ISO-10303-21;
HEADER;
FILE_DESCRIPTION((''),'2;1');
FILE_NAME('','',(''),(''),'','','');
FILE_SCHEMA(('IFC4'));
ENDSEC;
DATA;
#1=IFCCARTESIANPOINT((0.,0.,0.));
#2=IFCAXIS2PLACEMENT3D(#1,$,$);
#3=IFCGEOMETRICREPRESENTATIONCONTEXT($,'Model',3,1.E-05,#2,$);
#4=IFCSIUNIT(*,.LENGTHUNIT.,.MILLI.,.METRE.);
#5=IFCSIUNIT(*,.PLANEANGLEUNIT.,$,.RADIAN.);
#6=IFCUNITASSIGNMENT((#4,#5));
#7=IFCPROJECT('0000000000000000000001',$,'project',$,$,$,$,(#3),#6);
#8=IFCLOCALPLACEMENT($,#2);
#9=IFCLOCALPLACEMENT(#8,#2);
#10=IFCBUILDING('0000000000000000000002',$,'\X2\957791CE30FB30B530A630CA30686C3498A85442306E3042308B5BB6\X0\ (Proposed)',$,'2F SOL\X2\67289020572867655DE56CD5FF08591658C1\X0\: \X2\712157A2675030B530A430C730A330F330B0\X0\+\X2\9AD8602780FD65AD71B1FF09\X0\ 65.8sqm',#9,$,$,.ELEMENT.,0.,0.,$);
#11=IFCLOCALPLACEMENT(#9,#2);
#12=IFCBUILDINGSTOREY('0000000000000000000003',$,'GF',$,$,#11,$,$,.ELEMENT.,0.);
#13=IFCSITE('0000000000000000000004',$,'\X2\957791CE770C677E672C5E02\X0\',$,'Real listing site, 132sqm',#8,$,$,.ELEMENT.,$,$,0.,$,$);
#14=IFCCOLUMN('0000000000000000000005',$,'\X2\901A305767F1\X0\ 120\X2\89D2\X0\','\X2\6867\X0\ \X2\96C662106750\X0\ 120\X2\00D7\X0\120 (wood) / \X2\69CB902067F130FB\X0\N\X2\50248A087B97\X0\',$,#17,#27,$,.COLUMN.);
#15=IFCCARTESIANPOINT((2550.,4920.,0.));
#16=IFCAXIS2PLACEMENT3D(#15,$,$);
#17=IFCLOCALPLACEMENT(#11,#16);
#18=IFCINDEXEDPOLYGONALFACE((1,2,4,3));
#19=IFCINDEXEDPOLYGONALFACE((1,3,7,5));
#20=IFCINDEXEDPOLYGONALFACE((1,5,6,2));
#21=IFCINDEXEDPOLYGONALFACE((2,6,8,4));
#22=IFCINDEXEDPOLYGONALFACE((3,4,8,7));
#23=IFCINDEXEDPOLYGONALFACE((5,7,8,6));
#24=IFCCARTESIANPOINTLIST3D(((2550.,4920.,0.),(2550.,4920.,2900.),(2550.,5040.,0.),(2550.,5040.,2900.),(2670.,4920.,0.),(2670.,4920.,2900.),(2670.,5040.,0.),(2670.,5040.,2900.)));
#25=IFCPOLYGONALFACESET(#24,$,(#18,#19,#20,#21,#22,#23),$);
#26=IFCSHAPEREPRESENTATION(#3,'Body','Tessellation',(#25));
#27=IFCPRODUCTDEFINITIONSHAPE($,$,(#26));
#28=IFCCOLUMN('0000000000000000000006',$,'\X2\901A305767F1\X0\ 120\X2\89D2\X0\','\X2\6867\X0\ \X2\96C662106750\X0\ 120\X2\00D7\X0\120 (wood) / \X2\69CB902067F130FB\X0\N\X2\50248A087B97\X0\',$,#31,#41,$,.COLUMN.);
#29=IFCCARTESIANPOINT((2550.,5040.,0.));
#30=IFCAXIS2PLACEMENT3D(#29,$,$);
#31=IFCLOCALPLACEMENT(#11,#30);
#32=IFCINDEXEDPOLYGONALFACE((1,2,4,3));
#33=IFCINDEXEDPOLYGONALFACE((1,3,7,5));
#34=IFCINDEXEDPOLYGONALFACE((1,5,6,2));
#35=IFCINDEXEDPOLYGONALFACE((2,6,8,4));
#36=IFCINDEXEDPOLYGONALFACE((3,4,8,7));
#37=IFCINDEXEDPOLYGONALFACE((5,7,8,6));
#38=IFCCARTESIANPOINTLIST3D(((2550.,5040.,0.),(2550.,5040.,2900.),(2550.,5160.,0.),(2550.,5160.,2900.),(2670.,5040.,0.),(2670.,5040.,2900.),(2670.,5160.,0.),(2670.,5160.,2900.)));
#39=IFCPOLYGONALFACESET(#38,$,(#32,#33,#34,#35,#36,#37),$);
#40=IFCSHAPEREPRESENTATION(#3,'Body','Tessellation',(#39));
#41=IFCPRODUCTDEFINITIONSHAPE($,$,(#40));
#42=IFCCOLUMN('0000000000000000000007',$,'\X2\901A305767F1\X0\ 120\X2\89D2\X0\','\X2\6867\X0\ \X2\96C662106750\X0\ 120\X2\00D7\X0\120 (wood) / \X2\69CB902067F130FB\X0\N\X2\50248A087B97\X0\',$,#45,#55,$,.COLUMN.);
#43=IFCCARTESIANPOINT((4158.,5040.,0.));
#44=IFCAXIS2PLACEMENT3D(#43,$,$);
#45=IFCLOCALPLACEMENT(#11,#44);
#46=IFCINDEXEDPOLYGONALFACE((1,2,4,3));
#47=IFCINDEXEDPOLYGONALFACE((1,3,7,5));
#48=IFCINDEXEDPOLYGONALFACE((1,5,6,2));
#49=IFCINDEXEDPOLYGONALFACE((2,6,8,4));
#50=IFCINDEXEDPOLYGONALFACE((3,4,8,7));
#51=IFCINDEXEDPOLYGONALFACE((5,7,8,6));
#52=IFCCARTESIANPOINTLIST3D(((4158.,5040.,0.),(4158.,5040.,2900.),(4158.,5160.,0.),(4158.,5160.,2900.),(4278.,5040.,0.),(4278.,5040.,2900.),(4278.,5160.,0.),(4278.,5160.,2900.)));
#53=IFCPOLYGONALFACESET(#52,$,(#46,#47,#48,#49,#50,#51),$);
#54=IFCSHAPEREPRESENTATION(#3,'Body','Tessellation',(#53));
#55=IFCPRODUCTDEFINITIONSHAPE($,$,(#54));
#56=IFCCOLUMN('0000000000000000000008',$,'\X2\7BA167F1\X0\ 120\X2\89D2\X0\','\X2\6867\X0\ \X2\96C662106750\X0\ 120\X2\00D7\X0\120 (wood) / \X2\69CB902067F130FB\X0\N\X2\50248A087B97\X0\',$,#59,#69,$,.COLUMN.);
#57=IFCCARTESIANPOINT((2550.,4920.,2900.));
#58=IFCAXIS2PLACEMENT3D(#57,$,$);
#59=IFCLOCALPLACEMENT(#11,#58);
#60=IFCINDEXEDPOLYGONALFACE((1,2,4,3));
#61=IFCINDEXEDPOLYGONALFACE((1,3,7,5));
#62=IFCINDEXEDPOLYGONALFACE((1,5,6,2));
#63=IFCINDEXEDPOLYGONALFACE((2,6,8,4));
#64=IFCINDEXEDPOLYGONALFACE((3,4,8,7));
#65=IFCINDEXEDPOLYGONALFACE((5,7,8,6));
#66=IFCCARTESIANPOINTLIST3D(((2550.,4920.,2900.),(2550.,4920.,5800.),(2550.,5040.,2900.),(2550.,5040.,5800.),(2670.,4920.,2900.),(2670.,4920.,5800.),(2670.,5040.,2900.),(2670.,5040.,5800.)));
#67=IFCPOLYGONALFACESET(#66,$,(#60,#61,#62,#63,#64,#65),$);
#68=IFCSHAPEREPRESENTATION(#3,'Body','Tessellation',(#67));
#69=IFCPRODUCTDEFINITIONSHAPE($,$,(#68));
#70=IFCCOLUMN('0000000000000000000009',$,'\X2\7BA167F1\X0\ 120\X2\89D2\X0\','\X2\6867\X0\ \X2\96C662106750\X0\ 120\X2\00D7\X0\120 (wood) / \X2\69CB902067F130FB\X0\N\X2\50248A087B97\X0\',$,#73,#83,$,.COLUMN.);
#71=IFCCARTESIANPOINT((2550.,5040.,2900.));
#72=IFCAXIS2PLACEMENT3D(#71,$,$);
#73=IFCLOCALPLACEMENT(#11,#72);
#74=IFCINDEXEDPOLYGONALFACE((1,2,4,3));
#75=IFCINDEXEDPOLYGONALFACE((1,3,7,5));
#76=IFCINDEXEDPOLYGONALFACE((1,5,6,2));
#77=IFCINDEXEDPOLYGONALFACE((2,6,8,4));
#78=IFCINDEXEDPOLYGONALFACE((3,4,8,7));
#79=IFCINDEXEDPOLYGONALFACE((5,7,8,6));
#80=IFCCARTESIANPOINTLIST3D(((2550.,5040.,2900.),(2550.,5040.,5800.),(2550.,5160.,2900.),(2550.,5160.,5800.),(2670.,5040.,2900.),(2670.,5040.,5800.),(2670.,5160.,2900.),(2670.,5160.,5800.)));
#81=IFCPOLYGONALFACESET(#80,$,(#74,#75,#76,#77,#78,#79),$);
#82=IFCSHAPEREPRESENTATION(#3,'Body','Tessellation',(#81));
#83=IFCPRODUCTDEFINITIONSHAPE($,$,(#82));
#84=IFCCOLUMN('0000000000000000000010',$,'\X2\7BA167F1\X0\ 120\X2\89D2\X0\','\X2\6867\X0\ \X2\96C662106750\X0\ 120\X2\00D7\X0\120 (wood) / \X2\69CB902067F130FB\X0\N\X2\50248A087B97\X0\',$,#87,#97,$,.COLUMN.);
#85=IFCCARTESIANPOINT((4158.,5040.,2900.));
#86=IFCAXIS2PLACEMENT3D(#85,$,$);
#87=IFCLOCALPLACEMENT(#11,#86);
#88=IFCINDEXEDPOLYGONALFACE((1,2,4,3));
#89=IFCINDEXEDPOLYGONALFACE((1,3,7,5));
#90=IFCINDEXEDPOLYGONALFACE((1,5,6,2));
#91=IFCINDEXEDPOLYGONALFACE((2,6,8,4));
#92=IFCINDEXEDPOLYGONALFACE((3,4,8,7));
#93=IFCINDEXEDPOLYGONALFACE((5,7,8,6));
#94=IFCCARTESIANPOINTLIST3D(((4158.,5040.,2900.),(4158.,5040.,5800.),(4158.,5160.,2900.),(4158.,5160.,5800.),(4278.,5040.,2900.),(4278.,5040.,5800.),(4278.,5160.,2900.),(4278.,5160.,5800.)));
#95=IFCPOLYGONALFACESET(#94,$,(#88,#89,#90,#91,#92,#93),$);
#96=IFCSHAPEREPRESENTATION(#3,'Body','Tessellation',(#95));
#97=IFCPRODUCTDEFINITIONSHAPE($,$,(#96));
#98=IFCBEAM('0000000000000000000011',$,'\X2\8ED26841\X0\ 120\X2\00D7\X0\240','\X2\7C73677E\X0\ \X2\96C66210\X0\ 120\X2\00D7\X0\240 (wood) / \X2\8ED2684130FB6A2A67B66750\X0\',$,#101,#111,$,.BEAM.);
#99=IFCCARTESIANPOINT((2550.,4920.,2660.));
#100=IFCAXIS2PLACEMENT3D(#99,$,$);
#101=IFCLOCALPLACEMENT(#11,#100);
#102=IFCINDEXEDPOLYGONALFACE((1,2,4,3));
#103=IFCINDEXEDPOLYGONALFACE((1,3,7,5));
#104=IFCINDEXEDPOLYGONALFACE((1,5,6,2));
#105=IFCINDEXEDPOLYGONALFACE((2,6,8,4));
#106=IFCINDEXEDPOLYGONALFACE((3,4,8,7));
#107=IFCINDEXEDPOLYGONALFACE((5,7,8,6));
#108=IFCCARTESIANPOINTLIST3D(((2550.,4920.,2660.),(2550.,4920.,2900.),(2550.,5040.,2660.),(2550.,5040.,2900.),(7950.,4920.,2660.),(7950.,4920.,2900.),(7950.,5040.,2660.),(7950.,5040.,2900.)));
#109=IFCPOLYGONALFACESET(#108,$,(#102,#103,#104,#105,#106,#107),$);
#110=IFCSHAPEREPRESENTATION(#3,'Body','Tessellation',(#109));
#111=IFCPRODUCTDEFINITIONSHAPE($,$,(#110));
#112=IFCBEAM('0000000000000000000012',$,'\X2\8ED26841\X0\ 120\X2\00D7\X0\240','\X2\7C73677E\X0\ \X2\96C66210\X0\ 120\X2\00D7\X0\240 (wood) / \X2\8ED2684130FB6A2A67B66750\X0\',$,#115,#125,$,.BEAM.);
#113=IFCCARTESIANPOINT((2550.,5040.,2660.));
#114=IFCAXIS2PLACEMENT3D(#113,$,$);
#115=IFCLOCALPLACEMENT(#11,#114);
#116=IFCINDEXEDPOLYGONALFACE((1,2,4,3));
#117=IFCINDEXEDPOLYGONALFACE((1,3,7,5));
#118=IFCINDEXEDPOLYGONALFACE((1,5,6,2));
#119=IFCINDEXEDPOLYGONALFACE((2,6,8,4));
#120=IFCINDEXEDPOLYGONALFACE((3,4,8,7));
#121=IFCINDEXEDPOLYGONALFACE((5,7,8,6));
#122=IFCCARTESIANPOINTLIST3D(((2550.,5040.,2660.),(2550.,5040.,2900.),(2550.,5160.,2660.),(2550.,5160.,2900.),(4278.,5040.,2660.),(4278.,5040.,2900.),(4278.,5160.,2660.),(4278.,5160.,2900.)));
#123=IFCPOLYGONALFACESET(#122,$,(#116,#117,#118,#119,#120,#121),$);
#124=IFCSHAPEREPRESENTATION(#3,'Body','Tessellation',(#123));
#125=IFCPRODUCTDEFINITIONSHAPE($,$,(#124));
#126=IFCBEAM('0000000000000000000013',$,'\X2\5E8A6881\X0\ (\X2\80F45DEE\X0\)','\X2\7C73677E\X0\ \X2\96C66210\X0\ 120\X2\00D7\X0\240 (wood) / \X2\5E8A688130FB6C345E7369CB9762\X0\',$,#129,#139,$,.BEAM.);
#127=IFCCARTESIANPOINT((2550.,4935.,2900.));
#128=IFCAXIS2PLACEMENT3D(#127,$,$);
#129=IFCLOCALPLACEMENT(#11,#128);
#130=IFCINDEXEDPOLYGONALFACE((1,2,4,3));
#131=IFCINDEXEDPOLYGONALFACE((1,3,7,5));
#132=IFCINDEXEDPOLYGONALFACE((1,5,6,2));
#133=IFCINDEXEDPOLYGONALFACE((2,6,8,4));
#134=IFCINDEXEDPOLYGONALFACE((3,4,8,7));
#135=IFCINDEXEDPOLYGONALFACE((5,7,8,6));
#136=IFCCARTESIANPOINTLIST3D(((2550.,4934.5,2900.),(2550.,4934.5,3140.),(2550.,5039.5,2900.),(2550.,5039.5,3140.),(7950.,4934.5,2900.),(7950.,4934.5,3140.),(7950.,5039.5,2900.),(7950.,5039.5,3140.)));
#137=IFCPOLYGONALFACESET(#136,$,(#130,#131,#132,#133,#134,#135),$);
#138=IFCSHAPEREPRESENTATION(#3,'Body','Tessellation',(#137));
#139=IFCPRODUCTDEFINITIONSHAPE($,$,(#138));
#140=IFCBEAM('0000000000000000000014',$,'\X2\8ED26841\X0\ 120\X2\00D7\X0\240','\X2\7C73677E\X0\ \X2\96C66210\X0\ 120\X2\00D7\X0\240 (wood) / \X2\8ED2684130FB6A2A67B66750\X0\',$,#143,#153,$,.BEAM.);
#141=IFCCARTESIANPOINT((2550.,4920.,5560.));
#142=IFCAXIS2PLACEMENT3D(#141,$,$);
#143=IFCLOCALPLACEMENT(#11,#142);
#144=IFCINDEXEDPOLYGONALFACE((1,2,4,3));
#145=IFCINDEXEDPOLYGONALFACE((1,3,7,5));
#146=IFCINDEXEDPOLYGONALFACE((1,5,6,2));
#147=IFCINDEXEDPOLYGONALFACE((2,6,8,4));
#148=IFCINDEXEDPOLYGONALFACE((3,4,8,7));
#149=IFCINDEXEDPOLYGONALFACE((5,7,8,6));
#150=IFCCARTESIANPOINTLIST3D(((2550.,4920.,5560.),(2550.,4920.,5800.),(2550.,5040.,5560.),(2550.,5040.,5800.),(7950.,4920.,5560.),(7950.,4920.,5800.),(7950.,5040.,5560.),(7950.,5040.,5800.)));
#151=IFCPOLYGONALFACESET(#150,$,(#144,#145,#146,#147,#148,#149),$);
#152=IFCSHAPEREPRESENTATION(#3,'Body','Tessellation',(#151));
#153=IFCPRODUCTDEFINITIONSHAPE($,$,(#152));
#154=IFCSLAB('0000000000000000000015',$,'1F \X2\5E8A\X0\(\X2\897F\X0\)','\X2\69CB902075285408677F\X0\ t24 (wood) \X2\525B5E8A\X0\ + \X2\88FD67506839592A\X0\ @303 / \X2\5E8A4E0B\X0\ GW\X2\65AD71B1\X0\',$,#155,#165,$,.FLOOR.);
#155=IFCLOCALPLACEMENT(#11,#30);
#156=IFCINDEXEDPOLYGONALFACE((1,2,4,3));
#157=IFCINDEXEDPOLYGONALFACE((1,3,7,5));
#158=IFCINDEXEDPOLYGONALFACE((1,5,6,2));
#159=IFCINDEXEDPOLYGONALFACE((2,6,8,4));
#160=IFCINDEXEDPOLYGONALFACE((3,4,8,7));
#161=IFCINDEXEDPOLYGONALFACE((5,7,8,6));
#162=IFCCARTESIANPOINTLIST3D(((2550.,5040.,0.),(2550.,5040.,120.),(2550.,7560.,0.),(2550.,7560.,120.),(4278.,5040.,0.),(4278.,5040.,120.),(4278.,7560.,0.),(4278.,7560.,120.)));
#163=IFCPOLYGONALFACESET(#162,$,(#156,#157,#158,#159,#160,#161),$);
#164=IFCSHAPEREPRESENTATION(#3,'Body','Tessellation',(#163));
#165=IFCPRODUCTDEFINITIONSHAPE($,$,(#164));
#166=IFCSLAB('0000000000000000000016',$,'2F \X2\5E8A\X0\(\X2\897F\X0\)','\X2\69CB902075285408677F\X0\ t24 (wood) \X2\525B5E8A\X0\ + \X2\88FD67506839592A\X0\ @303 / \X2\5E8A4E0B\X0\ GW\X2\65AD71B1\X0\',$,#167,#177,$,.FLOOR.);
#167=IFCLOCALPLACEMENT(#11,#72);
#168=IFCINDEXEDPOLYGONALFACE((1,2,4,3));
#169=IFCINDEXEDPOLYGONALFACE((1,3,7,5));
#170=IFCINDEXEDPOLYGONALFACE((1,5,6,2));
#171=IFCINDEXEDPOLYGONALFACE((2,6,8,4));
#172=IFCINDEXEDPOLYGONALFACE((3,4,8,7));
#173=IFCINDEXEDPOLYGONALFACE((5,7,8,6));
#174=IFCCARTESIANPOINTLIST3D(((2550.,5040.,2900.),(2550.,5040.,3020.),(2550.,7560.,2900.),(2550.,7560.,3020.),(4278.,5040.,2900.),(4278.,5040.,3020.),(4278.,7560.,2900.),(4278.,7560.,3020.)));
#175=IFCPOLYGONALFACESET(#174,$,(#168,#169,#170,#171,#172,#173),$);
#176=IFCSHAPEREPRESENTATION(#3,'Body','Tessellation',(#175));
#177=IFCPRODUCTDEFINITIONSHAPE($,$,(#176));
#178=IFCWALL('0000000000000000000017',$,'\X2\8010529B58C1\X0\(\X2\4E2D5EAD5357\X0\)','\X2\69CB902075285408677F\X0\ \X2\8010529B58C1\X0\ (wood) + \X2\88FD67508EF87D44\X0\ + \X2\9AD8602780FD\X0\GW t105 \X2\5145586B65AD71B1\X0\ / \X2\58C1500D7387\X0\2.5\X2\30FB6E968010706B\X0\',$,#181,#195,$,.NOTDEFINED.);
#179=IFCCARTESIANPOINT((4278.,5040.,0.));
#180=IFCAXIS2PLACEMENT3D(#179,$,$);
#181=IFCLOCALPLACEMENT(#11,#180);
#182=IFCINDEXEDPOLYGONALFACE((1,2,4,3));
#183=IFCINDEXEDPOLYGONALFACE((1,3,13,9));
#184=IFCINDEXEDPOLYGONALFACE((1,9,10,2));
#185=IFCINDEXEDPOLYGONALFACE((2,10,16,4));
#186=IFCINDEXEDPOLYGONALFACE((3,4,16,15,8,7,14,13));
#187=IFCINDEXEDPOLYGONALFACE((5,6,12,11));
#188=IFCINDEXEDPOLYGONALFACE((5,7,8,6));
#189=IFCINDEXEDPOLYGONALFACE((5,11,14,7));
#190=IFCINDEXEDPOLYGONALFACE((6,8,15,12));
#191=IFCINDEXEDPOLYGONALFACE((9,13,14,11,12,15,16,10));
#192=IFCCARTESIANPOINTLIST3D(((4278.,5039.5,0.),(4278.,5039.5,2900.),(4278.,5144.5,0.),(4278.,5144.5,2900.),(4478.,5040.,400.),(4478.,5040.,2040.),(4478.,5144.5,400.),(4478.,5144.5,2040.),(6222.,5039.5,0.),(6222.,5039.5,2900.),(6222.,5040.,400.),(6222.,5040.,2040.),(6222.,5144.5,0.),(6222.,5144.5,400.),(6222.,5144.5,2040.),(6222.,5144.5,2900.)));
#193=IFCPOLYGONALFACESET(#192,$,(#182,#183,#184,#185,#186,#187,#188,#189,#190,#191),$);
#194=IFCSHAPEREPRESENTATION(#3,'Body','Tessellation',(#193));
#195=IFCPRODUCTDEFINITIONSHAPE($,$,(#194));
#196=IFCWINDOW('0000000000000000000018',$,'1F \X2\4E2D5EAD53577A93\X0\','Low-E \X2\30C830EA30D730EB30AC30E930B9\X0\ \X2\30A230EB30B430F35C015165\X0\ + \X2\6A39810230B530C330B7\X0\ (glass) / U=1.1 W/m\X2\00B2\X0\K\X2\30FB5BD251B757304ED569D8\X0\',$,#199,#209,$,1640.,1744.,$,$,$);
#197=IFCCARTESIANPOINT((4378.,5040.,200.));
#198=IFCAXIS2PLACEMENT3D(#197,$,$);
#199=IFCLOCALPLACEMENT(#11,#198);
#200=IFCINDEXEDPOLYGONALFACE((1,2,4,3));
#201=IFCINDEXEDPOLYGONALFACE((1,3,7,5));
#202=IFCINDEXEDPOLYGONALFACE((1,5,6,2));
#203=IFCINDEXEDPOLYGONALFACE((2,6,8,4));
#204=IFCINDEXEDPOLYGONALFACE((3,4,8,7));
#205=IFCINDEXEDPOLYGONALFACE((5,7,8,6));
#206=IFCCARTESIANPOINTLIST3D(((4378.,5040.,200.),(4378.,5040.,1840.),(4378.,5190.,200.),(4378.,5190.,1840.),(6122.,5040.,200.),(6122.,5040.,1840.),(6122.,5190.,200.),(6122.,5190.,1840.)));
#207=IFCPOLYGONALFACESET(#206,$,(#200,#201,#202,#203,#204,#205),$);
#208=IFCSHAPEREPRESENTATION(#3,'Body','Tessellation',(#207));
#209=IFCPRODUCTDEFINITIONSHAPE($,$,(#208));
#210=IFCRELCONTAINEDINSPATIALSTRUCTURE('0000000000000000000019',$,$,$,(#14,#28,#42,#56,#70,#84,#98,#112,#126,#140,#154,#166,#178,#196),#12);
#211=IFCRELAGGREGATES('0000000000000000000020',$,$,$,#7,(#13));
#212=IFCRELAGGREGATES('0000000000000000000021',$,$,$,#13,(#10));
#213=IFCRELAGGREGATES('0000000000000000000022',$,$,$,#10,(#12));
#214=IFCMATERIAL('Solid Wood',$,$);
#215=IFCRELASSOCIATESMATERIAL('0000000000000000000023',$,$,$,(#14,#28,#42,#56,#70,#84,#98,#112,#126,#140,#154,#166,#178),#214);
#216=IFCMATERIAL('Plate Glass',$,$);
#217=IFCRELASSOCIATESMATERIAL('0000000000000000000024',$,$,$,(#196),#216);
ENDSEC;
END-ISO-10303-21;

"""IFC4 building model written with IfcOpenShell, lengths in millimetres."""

from ifc_helpers import new_model, si_unit, frame, frame_2d, origin, place, context, project, spatial, rectangle, extrude, material, element, fill, save


model = new_model("IFC4")

# Units and contexts
model_context = context("Model", 3, precision=1e-05, world=origin())
ifc_project = project(units=[si_unit("LENGTHUNIT", "METRE", prefix="MILLI"), si_unit("PLANEANGLEUNIT", "RADIAN")], contexts=[model_context])

# Site, building, storey
site_placement = place(None, origin())
site = spatial("IfcSite", under=ifc_project, at=site_placement, Name="長野県松本市", ObjectType="Real listing site, 132sqm", CompositionType="ELEMENT", RefElevation=0.0)
building_placement = place(site_placement, origin())
building = spatial("IfcBuilding", under=site, at=building_placement, Name="長野・サウナと水風呂のある家 (Proposed)", ObjectType="2F SOL木造在来工法（外壁: 無垢材サイディング+高性能断熱） 65.8sqm", CompositionType="ELEMENT", ElevationOfRefHeight=0.0, ElevationOfTerrain=0.0)
storey_placement = place(building_placement, origin())
storey = spatial("IfcBuildingStorey", under=building, at=storey_placement, Name="GF", CompositionType="ELEMENT", Elevation=0.0)

# Columns
ifc_material_1 = material(Name="Solid Wood")
column_1_placement = place(storey_placement, frame((2550.0, 4920.0, 0.0)))
element("IfcColumn", 1, at=column_1_placement, inside=storey, material=ifc_material_1, Name="通し柱 120角", Description="桧 集成材 120×120 (wood) / 構造柱・N値計算", PredefinedType="COLUMN", context=model_context, shape_type="SweptSolid", body=[
    extrude(rectangle(XDim=120.0, YDim=120.0, at=frame_2d((60.0, 60.0))), frame((2550.0, 4920.0, 0.0)), (0.0, 0.0, 1.0), 2900.0),
])
column_2_placement = place(storey_placement, frame((2550.0, 5040.0, 0.0)))
element("IfcColumn", 2, at=column_2_placement, inside=storey, material=ifc_material_1, Name="通し柱 120角", Description="桧 集成材 120×120 (wood) / 構造柱・N値計算", PredefinedType="COLUMN", context=model_context, shape_type="SweptSolid", body=[
    extrude(rectangle(XDim=120.0, YDim=120.0, at=frame_2d((60.0, 60.0))), frame((2550.0, 5040.0, 0.0)), (0.0, 0.0, 1.0), 2900.0),
])
column_3_placement = place(storey_placement, frame((4158.0, 5040.0, 0.0)))
element("IfcColumn", 3, at=column_3_placement, inside=storey, material=ifc_material_1, Name="通し柱 120角", Description="桧 集成材 120×120 (wood) / 構造柱・N値計算", PredefinedType="COLUMN", context=model_context, shape_type="SweptSolid", body=[
    extrude(rectangle(XDim=120.0, YDim=120.0, at=frame_2d((60.0, 60.0))), frame((4158.0, 5040.0, 0.0)), (0.0, 0.0, 1.0), 2900.0),
])
column_4_placement = place(storey_placement, frame((2550.0, 4920.0, 2900.0)))
element("IfcColumn", 4, at=column_4_placement, inside=storey, material=ifc_material_1, Name="管柱 120角", Description="桧 集成材 120×120 (wood) / 構造柱・N値計算", PredefinedType="COLUMN", context=model_context, shape_type="SweptSolid", body=[
    extrude(rectangle(XDim=120.0, YDim=120.0, at=frame_2d((60.0, 60.0))), frame((2550.0, 4920.0, 2900.0)), (0.0, 0.0, 1.0), 2900.0),
])
column_5_placement = place(storey_placement, frame((2550.0, 5040.0, 2900.0)))
element("IfcColumn", 5, at=column_5_placement, inside=storey, material=ifc_material_1, Name="管柱 120角", Description="桧 集成材 120×120 (wood) / 構造柱・N値計算", PredefinedType="COLUMN", context=model_context, shape_type="SweptSolid", body=[
    extrude(rectangle(XDim=120.0, YDim=120.0, at=frame_2d((60.0, 60.0))), frame((2550.0, 5040.0, 2900.0)), (0.0, 0.0, 1.0), 2900.0),
])
column_6_placement = place(storey_placement, frame((4158.0, 5040.0, 2900.0)))
element("IfcColumn", 6, at=column_6_placement, inside=storey, material=ifc_material_1, Name="管柱 120角", Description="桧 集成材 120×120 (wood) / 構造柱・N値計算", PredefinedType="COLUMN", context=model_context, shape_type="SweptSolid", body=[
    extrude(rectangle(XDim=120.0, YDim=120.0, at=frame_2d((60.0, 60.0))), frame((4158.0, 5040.0, 2900.0)), (0.0, 0.0, 1.0), 2900.0),
])

# Beams
beam_1_placement = place(storey_placement, frame((2550.0, 4920.0, 2660.0)))
element("IfcBeam", 7, at=beam_1_placement, inside=storey, material=ifc_material_1, Name="軒桁 120×240", Description="米松 集成 120×240 (wood) / 軒桁・横架材", PredefinedType="BEAM", context=model_context, shape_type="SweptSolid", body=[
    extrude(rectangle(XDim=5400.0, YDim=120.0, at=frame_2d((2700.0, 60.0))), frame((2550.0, 4920.0, 2660.0)), (0.0, 0.0, 1.0), 240.0),
])
beam_2_placement = place(storey_placement, frame((2550.0, 5040.0, 2660.0)))
element("IfcBeam", 8, at=beam_2_placement, inside=storey, material=ifc_material_1, Name="軒桁 120×240", Description="米松 集成 120×240 (wood) / 軒桁・横架材", PredefinedType="BEAM", context=model_context, shape_type="SweptSolid", body=[
    extrude(rectangle(XDim=1728.0, YDim=120.0, at=frame_2d((864.0, 60.0))), frame((2550.0, 5040.0, 2660.0)), (0.0, 0.0, 1.0), 240.0),
])
beam_3_placement = place(storey_placement, frame((2550.0, 4935.0, 2900.0)))
element("IfcBeam", 9, at=beam_3_placement, inside=storey, material=ifc_material_1, Name="床梁 (胴差)", Description="米松 集成 120×240 (wood) / 床梁・水平構面", PredefinedType="BEAM", context=model_context, shape_type="SweptSolid", body=[
    extrude(rectangle(XDim=5400.0, YDim=105.0, at=frame_2d((2700.0, 52.0))), frame((2550.0, 4935.0, 2900.0)), (0.0, 0.0, 1.0), 240.0),
])
beam_4_placement = place(storey_placement, frame((2550.0, 4920.0, 5560.0)))
element("IfcBeam", 10, at=beam_4_placement, inside=storey, material=ifc_material_1, Name="軒桁 120×240", Description="米松 集成 120×240 (wood) / 軒桁・横架材", PredefinedType="BEAM", context=model_context, shape_type="SweptSolid", body=[
    extrude(rectangle(XDim=5400.0, YDim=120.0, at=frame_2d((2700.0, 60.0))), frame((2550.0, 4920.0, 5560.0)), (0.0, 0.0, 1.0), 240.0),
])

# Slabs
slab_1_placement = place(storey_placement, frame((2550.0, 5040.0, 0.0)))
element("IfcSlab", 11, at=slab_1_placement, inside=storey, material=ifc_material_1, Name="1F 床(西)", Description="構造用合板 t24 (wood) 剛床 + 製材根太 @303 / 床下 GW断熱", PredefinedType="FLOOR", context=model_context, shape_type="SweptSolid", body=[
    extrude(rectangle(XDim=1728.0, YDim=2520.0, at=frame_2d((864.0, 1260.0))), frame((2550.0, 5040.0, 0.0)), (0.0, 0.0, 1.0), 120.0),
])
slab_2_placement = place(storey_placement, frame((2550.0, 5040.0, 2900.0)))
element("IfcSlab", 12, at=slab_2_placement, inside=storey, material=ifc_material_1, Name="2F 床(西)", Description="構造用合板 t24 (wood) 剛床 + 製材根太 @303 / 床下 GW断熱", PredefinedType="FLOOR", context=model_context, shape_type="SweptSolid", body=[
    extrude(rectangle(XDim=1728.0, YDim=2520.0, at=frame_2d((864.0, 1260.0))), frame((2550.0, 5040.0, 2900.0)), (0.0, 0.0, 1.0), 120.0),
])

# Wall, opening, window
wall_1_placement = place(storey_placement, frame((4278.0, 5040.0, 0.0)))
wall_1 = element("IfcWall", 13, at=wall_1_placement, inside=storey, material=ifc_material_1, Name="耐力壁(中庭南)", Description="構造用合板 耐力壁 (wood) + 製材軸組 + 高性能GW t105 充填断熱 / 壁倍率2.5・準耐火", PredefinedType="NOTDEFINED", context=model_context, shape_type="SweptSolid", body=[
    extrude(rectangle(XDim=1944.0, YDim=105.0, at=frame_2d((972.0, 52.0))), frame((4278.0, 5040.0, 0.0)), (0.0, 0.0, 1.0), 2900.0),
])
opening_1_placement = place(storey_placement, frame((4378.0, 5040.0, 200.0)))
opening_1 = element("IfcOpeningElement", 14, at=opening_1_placement, cuts=wall_1, PredefinedType="NOTDEFINED", context=model_context, shape_type="SweptSolid", body=[
    extrude(rectangle(XDim=1744.0, YDim=150.0, at=frame_2d((872.0, 75.0))), frame((4378.0, 5040.0, 200.0)), (0.0, 0.0, 1.0), 1640.0),
])
ifc_material_2 = material(Name="Plate Glass")
window_1_placement = place(storey_placement, frame((4378.0, 5040.0, 200.0)))
window_1 = element("IfcWindow", 15, at=window_1_placement, inside=storey, material=ifc_material_2, Name="1F 中庭南窓", Description="Low-E トリプルガラス アルゴン封入 + 樹脂サッシ (glass) / U=1.1 W/m²K・寒冷地仕様", OverallHeight=1640.0, OverallWidth=1744.0, context=model_context, shape_type="SweptSolid", body=[
    extrude(rectangle(XDim=1744.0, YDim=150.0, at=frame_2d((872.0, 75.0))), frame((4378.0, 5040.0, 200.0)), (0.0, 0.0, 1.0), 1640.0),
])
fill(opening_1, window_1)

save(model, "model.ifc")
